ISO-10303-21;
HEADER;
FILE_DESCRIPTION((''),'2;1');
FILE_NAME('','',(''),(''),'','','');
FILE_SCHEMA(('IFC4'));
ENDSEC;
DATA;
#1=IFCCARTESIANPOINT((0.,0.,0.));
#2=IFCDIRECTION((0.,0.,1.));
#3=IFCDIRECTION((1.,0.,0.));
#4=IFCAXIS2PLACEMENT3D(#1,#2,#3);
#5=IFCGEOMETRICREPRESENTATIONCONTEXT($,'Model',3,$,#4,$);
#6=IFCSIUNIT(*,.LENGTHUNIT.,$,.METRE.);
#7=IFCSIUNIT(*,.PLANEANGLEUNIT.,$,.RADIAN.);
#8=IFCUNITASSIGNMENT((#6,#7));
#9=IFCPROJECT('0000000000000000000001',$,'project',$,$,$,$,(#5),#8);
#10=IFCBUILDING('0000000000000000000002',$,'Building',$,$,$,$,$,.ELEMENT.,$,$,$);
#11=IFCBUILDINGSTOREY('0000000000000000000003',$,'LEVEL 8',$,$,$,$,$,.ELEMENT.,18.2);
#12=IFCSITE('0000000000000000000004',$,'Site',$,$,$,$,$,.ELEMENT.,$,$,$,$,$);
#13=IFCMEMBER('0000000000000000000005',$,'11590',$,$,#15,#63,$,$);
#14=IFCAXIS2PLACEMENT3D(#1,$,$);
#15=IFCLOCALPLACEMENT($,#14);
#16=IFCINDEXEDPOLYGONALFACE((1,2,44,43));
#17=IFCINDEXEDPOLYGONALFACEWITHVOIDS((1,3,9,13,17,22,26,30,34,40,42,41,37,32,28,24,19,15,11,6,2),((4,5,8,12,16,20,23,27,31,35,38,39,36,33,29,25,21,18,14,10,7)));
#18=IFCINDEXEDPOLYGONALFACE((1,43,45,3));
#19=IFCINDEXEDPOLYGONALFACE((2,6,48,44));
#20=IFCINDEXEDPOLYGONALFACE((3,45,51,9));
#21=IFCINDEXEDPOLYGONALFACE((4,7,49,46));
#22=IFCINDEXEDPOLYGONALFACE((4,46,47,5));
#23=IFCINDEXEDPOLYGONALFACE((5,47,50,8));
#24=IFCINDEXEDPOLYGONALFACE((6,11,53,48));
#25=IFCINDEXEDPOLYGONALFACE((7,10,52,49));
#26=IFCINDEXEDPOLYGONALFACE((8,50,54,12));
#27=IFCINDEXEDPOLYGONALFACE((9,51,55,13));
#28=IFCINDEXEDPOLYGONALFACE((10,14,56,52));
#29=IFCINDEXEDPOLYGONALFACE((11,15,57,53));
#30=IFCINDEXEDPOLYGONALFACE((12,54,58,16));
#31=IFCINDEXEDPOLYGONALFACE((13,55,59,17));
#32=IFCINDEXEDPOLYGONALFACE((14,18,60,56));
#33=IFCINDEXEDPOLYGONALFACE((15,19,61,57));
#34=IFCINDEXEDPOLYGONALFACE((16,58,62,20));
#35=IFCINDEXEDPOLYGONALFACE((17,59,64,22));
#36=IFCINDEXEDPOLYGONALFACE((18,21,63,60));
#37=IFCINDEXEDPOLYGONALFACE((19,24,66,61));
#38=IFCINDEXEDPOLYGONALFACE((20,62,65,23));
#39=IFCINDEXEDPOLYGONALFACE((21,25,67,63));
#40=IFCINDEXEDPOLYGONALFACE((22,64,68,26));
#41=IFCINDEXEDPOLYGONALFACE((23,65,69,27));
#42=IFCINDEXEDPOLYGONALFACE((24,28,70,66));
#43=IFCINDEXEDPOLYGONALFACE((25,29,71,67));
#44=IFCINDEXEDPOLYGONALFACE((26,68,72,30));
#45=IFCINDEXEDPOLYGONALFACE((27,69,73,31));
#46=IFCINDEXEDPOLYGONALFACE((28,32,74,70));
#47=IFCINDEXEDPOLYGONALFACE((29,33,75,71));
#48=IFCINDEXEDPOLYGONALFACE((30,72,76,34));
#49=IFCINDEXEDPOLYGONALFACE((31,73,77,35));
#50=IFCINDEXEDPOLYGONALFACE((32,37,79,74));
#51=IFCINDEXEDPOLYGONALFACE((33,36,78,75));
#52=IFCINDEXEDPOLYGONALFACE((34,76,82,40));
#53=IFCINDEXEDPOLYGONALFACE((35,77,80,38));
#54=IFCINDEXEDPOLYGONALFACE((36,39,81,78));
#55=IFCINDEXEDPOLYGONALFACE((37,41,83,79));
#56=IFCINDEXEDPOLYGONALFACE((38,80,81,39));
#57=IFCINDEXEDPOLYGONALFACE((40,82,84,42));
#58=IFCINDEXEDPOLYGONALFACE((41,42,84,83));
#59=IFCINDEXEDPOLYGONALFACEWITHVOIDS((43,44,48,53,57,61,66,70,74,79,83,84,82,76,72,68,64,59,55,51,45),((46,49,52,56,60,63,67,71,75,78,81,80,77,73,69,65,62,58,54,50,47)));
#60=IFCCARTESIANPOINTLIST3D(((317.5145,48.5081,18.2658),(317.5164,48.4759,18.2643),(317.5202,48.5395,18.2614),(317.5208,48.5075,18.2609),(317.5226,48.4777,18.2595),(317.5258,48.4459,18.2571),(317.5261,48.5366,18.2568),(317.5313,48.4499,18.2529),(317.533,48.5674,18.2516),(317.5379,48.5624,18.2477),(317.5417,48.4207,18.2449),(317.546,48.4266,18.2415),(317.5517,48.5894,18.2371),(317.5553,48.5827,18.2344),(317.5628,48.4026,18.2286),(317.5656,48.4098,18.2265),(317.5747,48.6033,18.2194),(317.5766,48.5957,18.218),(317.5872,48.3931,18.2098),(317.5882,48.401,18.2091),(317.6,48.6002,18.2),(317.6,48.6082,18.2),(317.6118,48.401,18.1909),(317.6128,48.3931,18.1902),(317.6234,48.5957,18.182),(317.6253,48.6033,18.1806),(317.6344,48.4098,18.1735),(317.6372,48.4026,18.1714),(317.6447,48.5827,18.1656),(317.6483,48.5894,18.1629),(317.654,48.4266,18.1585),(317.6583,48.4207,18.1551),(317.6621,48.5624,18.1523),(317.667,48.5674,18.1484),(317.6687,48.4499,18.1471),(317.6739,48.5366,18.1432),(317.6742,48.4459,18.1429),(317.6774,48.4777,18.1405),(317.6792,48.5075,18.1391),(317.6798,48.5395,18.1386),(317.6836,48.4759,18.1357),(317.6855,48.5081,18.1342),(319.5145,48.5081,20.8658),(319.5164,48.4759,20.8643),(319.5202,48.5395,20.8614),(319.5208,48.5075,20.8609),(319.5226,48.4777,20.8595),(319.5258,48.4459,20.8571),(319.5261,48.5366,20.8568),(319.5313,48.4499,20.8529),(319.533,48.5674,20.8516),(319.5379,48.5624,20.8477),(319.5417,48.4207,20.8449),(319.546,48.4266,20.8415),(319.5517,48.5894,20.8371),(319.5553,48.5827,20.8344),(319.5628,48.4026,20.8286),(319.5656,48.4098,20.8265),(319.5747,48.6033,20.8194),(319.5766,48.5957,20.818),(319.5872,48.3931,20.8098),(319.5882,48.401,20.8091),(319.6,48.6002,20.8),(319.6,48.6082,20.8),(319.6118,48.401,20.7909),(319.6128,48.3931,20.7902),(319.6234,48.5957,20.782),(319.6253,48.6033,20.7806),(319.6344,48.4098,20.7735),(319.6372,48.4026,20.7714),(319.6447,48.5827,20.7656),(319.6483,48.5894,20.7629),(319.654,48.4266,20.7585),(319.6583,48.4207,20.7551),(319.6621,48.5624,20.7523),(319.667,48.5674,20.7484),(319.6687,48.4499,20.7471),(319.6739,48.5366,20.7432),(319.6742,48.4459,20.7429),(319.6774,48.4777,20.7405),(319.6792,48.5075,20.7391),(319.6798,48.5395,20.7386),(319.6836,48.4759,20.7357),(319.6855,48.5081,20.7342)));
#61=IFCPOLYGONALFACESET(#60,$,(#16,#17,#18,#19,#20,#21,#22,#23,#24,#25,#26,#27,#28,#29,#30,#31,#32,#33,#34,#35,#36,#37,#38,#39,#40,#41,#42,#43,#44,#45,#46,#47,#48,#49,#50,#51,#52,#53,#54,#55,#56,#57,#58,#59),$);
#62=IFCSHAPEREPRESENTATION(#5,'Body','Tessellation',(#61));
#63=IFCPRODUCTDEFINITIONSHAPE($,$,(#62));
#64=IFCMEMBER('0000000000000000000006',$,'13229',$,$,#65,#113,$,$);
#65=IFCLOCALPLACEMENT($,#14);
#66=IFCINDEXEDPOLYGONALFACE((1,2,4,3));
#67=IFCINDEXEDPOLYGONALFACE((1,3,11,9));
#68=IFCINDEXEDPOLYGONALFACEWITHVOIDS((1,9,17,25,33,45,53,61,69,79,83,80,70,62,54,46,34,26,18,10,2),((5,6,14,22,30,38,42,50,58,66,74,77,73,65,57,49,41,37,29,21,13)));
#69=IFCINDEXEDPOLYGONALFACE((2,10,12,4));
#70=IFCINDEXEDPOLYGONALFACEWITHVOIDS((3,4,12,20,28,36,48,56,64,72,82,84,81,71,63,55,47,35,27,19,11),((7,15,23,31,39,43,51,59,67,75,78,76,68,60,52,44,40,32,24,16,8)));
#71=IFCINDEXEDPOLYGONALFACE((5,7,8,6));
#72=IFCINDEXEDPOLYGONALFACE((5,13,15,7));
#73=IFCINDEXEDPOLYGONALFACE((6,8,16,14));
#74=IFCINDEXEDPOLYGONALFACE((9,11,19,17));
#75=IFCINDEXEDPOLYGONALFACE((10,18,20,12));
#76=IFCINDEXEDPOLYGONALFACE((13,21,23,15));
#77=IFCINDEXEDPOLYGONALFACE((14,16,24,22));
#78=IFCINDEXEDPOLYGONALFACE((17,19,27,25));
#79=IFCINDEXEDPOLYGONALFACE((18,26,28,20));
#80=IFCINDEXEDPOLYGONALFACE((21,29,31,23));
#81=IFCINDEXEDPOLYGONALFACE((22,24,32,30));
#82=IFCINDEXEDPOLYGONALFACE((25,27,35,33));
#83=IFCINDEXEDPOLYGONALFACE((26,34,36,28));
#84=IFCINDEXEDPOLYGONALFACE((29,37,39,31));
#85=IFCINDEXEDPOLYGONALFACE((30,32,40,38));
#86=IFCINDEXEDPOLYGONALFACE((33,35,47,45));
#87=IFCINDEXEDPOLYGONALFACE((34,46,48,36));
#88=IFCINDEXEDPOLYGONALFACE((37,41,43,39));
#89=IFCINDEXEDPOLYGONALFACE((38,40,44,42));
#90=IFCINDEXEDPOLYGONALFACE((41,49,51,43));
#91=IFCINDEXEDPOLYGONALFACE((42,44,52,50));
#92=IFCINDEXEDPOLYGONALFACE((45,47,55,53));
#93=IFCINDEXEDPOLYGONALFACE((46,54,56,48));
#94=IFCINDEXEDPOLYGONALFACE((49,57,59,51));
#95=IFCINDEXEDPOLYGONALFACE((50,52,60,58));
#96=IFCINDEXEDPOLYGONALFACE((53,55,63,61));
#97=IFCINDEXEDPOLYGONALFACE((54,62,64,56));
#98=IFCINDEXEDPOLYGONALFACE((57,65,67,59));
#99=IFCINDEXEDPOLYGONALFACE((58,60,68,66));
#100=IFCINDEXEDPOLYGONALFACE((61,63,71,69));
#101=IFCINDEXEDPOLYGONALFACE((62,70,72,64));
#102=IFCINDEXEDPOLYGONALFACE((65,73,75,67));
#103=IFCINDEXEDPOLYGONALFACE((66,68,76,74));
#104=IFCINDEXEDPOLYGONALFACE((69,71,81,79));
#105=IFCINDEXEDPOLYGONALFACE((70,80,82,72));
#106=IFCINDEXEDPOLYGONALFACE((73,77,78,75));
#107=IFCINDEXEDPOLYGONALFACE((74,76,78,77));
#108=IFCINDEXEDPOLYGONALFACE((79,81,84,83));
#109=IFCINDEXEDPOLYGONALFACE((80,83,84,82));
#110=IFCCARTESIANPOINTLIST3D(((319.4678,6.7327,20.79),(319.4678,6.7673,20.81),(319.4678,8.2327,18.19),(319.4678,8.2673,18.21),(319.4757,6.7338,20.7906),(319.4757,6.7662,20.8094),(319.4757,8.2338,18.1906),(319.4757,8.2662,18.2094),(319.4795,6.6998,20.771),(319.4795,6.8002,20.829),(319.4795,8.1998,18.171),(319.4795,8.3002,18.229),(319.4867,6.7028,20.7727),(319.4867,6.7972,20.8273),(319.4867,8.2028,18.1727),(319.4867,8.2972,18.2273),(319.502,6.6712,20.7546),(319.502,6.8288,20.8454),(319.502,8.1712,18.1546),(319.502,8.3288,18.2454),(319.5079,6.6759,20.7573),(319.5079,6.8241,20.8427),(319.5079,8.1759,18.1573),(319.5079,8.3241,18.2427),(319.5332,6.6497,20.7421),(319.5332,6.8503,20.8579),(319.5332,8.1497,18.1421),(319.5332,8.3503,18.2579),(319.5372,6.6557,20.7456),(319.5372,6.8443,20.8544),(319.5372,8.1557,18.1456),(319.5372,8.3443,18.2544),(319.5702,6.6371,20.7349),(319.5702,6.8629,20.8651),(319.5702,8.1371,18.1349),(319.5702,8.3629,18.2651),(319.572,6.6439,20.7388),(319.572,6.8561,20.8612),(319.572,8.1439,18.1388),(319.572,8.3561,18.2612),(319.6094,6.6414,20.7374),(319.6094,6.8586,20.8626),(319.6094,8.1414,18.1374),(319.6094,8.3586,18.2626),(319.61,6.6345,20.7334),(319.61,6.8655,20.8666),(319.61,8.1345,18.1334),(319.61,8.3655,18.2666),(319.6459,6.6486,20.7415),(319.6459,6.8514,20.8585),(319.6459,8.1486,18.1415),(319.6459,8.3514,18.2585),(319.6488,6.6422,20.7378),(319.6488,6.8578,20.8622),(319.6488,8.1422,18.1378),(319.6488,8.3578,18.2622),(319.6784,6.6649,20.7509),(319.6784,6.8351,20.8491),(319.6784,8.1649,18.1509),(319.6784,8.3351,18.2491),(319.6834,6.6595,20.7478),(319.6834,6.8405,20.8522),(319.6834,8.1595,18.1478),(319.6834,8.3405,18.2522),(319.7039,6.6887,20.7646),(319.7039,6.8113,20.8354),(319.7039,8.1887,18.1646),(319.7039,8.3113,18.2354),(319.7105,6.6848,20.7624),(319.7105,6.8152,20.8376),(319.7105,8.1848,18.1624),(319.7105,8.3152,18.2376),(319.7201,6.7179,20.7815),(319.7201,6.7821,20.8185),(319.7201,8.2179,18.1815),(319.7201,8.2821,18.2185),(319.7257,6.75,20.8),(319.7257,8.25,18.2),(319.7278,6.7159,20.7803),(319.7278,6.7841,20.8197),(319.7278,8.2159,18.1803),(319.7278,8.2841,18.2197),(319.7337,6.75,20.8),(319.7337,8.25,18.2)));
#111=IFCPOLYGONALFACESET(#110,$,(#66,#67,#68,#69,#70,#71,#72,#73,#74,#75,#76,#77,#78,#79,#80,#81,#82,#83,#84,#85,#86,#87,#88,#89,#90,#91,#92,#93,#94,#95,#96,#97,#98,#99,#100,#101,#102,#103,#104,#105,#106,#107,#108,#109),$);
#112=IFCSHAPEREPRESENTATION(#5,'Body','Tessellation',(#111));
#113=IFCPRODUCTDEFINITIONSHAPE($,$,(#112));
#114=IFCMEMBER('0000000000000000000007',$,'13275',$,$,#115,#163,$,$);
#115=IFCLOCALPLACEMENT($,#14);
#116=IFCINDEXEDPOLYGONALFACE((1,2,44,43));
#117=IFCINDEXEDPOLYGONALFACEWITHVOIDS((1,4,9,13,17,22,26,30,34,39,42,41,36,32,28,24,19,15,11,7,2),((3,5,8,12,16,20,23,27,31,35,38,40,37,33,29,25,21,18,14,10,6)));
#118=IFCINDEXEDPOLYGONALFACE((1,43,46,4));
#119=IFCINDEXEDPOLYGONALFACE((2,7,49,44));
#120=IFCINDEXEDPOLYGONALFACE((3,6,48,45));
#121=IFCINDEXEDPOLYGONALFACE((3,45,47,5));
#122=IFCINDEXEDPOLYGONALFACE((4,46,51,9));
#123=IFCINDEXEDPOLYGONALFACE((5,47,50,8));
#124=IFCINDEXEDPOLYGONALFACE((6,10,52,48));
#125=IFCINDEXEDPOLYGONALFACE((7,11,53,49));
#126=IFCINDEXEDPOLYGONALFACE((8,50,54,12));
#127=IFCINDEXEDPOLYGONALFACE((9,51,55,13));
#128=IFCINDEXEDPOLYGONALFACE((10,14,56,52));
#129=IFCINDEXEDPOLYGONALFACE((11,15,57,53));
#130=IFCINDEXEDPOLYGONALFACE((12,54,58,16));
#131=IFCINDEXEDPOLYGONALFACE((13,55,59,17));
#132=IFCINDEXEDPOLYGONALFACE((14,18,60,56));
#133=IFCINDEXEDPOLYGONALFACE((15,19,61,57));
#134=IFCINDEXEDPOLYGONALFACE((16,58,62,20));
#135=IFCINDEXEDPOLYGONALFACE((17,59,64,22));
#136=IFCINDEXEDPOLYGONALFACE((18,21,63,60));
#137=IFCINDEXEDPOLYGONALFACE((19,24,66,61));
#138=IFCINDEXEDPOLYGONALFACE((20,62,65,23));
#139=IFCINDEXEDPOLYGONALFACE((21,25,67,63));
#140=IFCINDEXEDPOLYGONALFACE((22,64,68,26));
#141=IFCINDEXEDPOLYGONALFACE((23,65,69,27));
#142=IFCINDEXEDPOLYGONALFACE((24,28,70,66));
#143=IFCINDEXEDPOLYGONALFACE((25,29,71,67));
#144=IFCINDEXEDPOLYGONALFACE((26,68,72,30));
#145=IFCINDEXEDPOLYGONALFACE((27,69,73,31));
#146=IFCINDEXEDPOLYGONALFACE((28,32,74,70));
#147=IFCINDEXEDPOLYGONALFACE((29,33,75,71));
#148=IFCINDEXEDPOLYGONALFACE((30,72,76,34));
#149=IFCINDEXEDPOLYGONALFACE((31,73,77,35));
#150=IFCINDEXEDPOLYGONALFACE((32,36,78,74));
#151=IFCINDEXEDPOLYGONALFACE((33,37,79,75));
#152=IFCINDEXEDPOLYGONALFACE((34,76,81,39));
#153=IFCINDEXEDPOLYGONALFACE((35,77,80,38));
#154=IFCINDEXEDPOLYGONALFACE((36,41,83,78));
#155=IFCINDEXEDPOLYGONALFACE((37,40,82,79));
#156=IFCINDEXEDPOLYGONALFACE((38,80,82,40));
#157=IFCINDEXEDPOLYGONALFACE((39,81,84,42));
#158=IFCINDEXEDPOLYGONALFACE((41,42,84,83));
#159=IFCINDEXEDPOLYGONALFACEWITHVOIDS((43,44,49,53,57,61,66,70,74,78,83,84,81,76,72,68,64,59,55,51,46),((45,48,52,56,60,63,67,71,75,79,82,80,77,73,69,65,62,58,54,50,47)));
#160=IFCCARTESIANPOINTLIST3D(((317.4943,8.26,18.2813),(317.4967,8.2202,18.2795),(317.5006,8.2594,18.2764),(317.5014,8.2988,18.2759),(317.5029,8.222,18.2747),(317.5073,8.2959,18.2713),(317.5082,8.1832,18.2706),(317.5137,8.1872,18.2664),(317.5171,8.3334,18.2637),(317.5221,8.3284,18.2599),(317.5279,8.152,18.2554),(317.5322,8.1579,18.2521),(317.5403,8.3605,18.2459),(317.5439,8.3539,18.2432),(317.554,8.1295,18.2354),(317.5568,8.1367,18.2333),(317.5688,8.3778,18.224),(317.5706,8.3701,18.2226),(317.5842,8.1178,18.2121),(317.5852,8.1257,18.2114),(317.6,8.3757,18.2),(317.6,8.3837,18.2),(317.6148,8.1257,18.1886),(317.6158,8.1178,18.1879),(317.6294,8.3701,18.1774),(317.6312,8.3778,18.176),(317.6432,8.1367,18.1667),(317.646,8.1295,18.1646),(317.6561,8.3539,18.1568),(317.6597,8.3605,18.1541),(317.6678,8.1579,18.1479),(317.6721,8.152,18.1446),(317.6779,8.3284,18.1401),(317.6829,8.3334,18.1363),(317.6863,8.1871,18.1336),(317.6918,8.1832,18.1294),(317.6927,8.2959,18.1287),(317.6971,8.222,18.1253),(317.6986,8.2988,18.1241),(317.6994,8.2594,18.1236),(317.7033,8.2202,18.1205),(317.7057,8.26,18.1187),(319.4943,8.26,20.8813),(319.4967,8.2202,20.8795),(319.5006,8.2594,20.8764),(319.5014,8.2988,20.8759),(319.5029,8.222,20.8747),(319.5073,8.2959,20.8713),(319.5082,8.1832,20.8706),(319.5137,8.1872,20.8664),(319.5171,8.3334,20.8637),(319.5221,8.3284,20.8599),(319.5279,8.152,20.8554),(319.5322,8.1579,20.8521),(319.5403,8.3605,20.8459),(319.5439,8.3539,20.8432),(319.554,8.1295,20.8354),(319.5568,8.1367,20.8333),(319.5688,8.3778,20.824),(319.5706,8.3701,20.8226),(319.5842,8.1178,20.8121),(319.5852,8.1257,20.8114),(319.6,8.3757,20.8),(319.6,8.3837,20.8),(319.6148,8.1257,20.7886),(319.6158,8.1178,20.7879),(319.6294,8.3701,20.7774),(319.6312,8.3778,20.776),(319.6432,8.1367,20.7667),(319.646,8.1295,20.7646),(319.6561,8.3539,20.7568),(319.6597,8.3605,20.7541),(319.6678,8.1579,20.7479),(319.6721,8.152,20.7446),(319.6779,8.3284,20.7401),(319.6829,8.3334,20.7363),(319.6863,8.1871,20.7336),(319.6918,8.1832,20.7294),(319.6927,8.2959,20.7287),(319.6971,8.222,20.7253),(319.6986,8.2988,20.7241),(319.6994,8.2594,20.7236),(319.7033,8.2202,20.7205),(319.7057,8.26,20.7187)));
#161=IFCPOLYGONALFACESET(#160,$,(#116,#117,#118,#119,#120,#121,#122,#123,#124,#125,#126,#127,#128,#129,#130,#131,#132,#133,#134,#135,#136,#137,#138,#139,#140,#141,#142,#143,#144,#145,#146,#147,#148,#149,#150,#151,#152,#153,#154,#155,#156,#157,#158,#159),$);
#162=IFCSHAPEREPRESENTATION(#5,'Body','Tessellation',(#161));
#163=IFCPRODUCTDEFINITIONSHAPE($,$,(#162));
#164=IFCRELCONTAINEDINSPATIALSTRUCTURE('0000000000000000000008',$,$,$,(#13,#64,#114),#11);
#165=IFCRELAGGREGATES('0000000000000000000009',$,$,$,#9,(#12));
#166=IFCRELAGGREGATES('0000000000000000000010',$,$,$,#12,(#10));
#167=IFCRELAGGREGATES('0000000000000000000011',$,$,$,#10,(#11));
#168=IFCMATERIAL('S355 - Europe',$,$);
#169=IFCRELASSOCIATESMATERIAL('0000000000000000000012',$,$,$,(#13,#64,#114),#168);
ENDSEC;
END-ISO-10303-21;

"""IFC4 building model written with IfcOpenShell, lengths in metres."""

from ifc_helpers import new_model, si_unit, frame, origin_with_axes, origin_2d_with_axis, place, context, project, spatial, hollow_circle, extrude, material, material_profile, profile_set, profile_usage, element, save


model = new_model("IFC4")

# Units and contexts
model_context = context("Model", 3, world=origin_with_axes())
ifc_project = project(units=[si_unit("LENGTHUNIT", "METRE"), si_unit("PLANEANGLEUNIT", "RADIAN")], contexts=[model_context])

# Site, building, storey
site = spatial("IfcSite", under=ifc_project, Name="Site", CompositionType="ELEMENT")
building = spatial("IfcBuilding", under=site, Name="Building", CompositionType="ELEMENT")
storey = spatial("IfcBuildingStorey", under=building, Name="LEVEL 8", CompositionType="ELEMENT", Elevation=18.2)

# Shared definitions
ifc_material = material(Name="S355 - Europe")

# Members
ifc_material_profile_1 = material_profile(ifc_material, hollow_circle(Radius=0.1081, WallThickness=0.008, at=origin_2d_with_axis()))
ifc_profile_set_1 = profile_set([ifc_material_profile_1])
ifc_profile_usage_1 = profile_usage(ifc_profile_set_1, cardinal=10)
member_1_placement = place(None, frame((317.6, 48.5, 18.2), z_axis=(0.609711, 0.0, 0.792624), x_axis=(0.0, 1.0, 0.0)))
element("IfcMember", 1, at=member_1_placement, inside=storey, material=ifc_profile_usage_1, Name="11590", context=model_context, shape_type="SweptSolid", body=[
    extrude(hollow_circle(Radius=0.1081, WallThickness=0.008, at=origin_2d_with_axis()), origin_with_axes(), (0.0, 0.0, 1.0), 3.2802),
])
ifc_material_profile_2 = material_profile(ifc_material, hollow_circle(Radius=0.1337, WallThickness=0.008, at=origin_2d_with_axis()))
ifc_profile_set_2 = profile_set([ifc_material_profile_2])
ifc_profile_usage_2 = profile_usage(ifc_profile_set_2, cardinal=10)
member_2_placement = place(None, frame((319.6, 8.25, 18.2), z_axis=(0.0, -0.499722, 0.866186), x_axis=(1.0, 0.0, 0.0)))
element("IfcMember", 2, at=member_2_placement, inside=storey, material=ifc_profile_usage_2, Name="13229", context=model_context, shape_type="SweptSolid", body=[
    extrude(hollow_circle(Radius=0.1337, WallThickness=0.008, at=origin_2d_with_axis()), origin_with_axes(), (0.0, 0.0, 1.0), 3.0017),
])
ifc_material_profile_3 = material_profile(ifc_material, hollow_circle(Radius=0.1337, WallThickness=0.008, at=origin_2d_with_axis()))
ifc_profile_set_3 = profile_set([ifc_material_profile_3])
ifc_profile_usage_3 = profile_usage(ifc_profile_set_3, cardinal=10)
member_3_placement = place(None, frame((317.6, 8.25, 18.2), z_axis=(0.609711, 0.0, 0.792624), x_axis=(0.0, 1.0, 0.0)))
element("IfcMember", 3, at=member_3_placement, inside=storey, material=ifc_profile_usage_3, Name="13275", context=model_context, shape_type="SweptSolid", body=[
    extrude(hollow_circle(Radius=0.1337, WallThickness=0.008, at=origin_2d_with_axis()), origin_with_axes(), (0.0, 0.0, 1.0), 3.2802),
])

save(model, "model.ifc")
